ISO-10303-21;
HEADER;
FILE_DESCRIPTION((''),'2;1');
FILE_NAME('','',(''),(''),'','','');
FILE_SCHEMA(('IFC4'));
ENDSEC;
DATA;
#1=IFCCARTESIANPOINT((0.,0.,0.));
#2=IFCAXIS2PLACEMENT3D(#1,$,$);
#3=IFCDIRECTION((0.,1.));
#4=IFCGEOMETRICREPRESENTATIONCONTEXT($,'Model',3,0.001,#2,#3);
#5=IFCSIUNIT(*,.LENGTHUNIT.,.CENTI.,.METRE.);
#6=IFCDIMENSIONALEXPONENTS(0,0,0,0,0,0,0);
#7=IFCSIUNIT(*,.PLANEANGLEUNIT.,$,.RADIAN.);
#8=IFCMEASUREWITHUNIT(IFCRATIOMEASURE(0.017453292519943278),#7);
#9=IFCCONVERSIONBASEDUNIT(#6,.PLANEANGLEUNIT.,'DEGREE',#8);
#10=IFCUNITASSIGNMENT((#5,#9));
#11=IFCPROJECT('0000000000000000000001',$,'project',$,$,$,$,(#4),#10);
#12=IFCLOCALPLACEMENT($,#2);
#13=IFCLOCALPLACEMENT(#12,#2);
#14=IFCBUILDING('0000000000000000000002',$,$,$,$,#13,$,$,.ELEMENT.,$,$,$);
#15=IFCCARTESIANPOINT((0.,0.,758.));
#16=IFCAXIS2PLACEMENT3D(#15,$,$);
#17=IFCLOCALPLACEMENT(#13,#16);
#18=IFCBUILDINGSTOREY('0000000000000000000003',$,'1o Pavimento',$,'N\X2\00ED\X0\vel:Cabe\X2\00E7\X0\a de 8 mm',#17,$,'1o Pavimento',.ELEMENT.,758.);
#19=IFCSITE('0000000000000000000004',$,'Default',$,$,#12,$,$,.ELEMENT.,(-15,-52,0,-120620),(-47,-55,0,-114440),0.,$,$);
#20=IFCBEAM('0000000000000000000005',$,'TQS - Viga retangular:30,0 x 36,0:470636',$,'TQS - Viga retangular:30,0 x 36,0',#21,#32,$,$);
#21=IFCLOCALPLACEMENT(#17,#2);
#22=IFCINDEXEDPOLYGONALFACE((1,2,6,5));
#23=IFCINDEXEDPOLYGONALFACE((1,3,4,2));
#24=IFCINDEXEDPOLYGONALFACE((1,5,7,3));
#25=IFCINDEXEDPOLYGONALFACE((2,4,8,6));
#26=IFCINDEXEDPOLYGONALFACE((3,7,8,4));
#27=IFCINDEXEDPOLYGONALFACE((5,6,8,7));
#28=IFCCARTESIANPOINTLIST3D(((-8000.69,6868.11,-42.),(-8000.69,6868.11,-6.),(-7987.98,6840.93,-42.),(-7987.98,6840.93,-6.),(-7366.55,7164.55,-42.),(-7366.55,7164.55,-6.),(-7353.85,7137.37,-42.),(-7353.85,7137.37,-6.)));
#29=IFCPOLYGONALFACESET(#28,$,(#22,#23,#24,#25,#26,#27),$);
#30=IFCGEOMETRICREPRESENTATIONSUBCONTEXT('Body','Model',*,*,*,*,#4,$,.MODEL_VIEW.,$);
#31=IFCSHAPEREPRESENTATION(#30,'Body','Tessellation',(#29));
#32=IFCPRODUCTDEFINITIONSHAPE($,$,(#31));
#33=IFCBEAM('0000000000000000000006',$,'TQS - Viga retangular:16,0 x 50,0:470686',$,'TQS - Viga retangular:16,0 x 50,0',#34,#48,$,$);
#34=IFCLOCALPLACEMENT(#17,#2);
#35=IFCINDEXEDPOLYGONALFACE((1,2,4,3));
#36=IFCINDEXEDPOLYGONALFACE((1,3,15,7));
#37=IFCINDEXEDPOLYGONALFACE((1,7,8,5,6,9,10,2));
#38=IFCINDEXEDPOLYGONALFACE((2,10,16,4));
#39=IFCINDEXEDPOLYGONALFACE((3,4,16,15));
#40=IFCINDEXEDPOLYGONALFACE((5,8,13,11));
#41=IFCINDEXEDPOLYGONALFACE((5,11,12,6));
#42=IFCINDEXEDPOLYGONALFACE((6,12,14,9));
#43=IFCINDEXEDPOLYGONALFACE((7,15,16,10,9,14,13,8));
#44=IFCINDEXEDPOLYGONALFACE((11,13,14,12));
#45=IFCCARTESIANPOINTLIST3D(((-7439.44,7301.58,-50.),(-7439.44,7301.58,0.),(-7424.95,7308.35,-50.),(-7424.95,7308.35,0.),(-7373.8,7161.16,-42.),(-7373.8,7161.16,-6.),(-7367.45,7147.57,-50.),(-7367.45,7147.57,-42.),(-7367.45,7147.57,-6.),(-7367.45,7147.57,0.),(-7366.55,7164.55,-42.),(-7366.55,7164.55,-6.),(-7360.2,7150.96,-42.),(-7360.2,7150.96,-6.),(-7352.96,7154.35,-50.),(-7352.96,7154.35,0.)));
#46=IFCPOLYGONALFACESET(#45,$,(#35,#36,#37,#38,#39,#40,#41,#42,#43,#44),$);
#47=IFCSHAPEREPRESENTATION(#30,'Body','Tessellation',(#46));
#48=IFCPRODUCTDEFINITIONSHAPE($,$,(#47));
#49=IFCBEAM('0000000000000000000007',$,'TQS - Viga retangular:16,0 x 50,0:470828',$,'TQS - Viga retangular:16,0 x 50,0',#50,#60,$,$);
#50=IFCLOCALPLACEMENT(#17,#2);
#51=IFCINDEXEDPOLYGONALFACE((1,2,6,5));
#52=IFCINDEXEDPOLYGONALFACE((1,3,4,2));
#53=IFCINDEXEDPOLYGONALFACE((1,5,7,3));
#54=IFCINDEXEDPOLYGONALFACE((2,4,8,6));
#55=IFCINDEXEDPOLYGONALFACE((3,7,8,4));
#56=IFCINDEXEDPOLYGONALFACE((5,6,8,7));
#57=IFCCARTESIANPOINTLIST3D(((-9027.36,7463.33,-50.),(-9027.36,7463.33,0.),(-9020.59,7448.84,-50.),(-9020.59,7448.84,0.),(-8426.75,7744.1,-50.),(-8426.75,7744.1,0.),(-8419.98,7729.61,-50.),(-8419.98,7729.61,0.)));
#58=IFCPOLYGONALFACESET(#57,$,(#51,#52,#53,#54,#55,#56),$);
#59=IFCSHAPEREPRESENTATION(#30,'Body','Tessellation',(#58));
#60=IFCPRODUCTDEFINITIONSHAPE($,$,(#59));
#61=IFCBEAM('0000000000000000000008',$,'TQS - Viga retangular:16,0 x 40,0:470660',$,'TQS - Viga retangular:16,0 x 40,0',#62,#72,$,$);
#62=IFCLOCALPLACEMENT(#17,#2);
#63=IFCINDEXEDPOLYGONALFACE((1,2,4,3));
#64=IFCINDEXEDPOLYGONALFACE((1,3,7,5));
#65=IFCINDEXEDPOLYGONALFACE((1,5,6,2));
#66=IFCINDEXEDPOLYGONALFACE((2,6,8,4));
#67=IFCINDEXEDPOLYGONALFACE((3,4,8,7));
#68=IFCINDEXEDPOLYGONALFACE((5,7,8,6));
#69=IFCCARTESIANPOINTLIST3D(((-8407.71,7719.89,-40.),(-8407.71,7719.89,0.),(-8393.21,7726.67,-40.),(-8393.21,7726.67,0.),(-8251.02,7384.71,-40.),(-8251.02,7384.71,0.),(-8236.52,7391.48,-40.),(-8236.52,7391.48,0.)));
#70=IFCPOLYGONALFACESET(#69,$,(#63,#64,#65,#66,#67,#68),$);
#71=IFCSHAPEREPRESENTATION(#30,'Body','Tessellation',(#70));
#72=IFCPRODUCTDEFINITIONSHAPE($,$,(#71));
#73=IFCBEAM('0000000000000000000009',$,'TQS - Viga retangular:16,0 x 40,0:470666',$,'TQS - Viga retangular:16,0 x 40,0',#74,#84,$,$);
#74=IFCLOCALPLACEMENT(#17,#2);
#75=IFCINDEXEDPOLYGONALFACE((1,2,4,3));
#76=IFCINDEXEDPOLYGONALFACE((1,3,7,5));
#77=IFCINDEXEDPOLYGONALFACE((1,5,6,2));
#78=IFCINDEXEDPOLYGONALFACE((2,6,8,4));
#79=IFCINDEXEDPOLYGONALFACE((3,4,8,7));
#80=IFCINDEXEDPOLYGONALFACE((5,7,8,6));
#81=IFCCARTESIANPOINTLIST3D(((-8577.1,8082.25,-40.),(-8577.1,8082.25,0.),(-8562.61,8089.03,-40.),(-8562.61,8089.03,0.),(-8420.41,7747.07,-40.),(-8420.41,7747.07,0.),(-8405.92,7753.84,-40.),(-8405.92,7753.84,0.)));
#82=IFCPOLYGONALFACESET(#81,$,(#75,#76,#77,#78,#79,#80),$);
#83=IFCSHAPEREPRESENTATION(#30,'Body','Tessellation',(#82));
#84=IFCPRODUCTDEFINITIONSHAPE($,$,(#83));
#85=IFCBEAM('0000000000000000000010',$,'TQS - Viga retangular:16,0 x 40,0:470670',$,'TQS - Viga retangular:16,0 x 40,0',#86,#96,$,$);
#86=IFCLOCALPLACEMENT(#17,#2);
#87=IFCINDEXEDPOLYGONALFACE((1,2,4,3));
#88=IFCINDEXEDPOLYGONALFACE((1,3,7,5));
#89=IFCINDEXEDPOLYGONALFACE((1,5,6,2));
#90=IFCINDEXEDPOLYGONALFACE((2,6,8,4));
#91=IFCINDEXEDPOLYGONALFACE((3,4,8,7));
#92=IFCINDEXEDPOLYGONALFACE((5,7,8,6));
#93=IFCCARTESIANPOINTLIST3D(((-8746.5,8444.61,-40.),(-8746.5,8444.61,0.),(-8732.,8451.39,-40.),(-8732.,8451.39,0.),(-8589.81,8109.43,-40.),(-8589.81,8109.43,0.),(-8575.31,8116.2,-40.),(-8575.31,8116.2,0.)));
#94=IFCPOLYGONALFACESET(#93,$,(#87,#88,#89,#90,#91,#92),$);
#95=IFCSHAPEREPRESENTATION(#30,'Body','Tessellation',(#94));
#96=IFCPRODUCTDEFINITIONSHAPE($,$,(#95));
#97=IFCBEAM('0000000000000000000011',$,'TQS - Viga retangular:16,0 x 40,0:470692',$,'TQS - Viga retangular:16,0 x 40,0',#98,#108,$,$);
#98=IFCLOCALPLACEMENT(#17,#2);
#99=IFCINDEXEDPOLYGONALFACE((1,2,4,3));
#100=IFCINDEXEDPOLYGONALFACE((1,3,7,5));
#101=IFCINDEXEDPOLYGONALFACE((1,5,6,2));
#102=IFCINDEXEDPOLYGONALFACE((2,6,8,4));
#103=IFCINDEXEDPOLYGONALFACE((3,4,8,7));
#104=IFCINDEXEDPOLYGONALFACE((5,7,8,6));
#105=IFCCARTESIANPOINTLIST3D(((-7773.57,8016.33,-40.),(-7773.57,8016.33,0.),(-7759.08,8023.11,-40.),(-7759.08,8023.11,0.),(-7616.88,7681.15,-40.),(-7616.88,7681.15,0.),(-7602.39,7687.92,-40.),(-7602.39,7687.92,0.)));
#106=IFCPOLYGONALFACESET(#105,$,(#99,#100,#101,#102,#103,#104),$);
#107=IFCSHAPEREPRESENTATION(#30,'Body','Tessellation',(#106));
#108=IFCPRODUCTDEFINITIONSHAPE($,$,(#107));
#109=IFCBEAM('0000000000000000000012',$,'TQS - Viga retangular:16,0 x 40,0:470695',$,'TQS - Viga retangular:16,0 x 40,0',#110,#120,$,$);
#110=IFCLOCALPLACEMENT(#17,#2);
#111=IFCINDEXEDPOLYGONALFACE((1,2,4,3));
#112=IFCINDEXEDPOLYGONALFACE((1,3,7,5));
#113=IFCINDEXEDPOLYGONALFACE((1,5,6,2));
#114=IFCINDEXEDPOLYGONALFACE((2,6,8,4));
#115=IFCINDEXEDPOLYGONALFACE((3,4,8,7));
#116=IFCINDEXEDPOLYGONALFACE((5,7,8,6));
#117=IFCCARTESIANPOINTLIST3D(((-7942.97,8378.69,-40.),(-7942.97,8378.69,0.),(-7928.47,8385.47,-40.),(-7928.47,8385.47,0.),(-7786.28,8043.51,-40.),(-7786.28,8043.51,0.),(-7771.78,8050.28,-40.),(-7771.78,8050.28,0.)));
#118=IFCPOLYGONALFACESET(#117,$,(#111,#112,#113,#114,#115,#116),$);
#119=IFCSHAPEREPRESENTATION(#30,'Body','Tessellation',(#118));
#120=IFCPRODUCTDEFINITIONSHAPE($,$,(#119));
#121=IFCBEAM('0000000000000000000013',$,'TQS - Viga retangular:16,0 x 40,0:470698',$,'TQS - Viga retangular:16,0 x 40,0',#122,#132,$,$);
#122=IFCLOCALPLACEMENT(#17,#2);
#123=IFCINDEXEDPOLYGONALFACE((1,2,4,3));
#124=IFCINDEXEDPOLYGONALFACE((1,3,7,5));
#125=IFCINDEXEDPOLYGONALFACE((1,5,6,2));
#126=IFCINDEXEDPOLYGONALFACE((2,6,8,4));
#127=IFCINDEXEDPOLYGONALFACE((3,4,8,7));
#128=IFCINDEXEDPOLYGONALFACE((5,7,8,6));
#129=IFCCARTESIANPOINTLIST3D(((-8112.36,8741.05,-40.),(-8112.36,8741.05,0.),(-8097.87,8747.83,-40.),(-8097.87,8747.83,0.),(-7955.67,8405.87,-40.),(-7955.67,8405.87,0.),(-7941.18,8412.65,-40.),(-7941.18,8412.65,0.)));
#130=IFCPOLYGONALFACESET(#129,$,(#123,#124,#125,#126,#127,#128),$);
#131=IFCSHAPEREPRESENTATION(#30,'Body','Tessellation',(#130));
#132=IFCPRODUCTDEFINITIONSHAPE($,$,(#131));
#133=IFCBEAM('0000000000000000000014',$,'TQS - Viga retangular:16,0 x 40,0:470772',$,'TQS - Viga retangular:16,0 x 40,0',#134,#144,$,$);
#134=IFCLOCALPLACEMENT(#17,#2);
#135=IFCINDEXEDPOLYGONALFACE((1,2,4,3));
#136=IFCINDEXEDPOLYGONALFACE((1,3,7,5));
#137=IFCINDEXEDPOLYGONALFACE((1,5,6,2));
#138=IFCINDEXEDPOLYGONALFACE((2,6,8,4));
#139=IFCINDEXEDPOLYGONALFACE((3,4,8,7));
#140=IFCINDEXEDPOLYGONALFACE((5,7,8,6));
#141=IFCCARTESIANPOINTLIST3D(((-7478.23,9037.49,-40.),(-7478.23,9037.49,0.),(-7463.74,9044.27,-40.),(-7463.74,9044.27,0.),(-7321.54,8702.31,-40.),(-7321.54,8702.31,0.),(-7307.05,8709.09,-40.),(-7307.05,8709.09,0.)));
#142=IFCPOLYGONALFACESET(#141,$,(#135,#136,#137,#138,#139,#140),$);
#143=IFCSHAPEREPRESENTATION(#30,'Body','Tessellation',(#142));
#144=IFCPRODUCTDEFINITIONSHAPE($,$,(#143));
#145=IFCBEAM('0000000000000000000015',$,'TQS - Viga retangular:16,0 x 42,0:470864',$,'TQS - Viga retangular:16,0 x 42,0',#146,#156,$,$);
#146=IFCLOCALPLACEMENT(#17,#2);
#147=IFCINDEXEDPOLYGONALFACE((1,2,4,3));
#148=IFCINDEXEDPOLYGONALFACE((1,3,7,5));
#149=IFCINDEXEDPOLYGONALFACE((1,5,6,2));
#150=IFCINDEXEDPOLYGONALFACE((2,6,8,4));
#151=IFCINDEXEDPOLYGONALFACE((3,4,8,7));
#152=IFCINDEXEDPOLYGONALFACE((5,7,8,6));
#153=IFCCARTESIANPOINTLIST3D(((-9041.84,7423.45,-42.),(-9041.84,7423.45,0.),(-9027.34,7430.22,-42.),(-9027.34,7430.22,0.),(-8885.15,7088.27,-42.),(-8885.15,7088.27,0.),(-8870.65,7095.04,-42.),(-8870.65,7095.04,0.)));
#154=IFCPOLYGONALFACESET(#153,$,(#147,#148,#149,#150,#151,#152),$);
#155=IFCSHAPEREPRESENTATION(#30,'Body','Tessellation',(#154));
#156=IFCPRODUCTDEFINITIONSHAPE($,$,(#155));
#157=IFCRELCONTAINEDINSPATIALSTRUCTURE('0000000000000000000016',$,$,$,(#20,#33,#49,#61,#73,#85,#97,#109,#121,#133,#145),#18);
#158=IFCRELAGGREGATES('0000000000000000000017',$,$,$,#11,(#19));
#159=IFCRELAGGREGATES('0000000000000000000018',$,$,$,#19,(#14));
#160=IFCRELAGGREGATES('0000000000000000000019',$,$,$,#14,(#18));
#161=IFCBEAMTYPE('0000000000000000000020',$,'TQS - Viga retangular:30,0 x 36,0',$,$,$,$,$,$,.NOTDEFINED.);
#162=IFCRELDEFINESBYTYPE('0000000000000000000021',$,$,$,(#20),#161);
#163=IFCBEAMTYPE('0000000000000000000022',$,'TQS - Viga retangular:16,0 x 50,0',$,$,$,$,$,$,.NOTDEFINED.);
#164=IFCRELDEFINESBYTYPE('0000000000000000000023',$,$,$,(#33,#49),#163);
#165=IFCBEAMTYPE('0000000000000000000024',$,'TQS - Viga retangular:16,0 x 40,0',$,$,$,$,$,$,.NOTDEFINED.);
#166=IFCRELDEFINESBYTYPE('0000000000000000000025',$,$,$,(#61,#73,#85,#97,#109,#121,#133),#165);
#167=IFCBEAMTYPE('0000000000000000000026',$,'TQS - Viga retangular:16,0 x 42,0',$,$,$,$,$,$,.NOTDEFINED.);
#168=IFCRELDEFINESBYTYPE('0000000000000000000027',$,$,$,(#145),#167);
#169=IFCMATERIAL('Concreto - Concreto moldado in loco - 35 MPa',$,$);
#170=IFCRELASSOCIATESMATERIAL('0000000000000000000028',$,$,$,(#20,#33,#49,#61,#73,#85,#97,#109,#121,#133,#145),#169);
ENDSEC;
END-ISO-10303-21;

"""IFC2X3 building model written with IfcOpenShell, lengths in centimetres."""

from ifc_helpers import new_model, entity, si_unit, converted_unit, direction, frame, frame_2d, origin, origin_2d_with_axis, place, context, subcontext, project, spatial, polyline, rectangle, extrude, boolean, clip, bounded_halfspace, material, type_object, element, save


model = new_model("IFC2X3")

# Units and contexts
model_context = context("Model", 3, precision=0.001, world=origin(), true_north=direction((0.0, 1.0)))
body_context = subcontext(model_context, "Body", "Model", "MODEL_VIEW")
ifc_project = project(units=[si_unit("LENGTHUNIT", "METRE", prefix="CENTI"), converted_unit("PLANEANGLEUNIT", "DEGREE", entity("IfcRatioMeasure", 0.017453292519943278), si_unit("PLANEANGLEUNIT", "RADIAN"), dimensions=[0, 0, 0, 0, 0, 0, 0])], contexts=[model_context])

# Site, building, storey
site_placement = place(None, origin())
site = spatial("IfcSite", under=ifc_project, at=site_placement, Name="Default", CompositionType="ELEMENT", RefLatitude=(-15, -52, 0, -120620), RefLongitude=(-47, -55, 0, -114440), RefElevation=0.0)
building_placement = place(site_placement, origin())
building = spatial("IfcBuilding", under=site, at=building_placement, CompositionType="ELEMENT")
storey_placement = place(building_placement, frame((0.0, 0.0, 758.0)))
storey = spatial("IfcBuildingStorey", under=building, at=storey_placement, Name="1o Pavimento", ObjectType="Nível:Cabeça de 8 mm", LongName="1o Pavimento", CompositionType="ELEMENT", Elevation=758.0)

# Beams
ifc_material_1 = material(Name="Concreto - Concreto moldado in loco - 35 MPa")
beam_type_1 = type_object("IfcBeamType", Name="TQS - Viga retangular:30,0 x 36,0", PredefinedType="NOTDEFINED")
beam_1_placement = place(storey_placement, frame((-7994.33, 6854.52, -6.0), z_axis=(0.0, 0.0, 1.0), x_axis=(0.905902, 0.423488, 0.0)))
element("IfcBeam", 1, at=beam_1_placement, inside=storey, type_object=beam_type_1, material=ifc_material_1, Name="TQS - Viga retangular:30,0 x 36,0:470636", ObjectType="TQS - Viga retangular:30,0 x 36,0", context=body_context, shape_type="SweptSolid", body=[
    extrude(rectangle(XDim=36.0, YDim=30.0, at=origin_2d_with_axis()), frame((0.0, 0.0, -18.0), z_axis=(1.0, 0.0, 0.0), x_axis=(0.0, 0.0, -1.0)), (0.0, 0.0, 1.0), 700.0),
])
beam_type_2 = type_object("IfcBeamType", Name="TQS - Viga retangular:16,0 x 50,0", PredefinedType="NOTDEFINED")
beam_2_placement = place(storey_placement, frame((-7360.2, 7150.96, 0.0), z_axis=(0.0, 0.0, 1.0), x_axis=(-0.423488, 0.905902, 0.0)))
element("IfcBeam", 2, at=beam_2_placement, inside=storey, type_object=beam_type_2, material=ifc_material_1, Name="TQS - Viga retangular:16,0 x 50,0:470686", ObjectType="TQS - Viga retangular:16,0 x 50,0", context=body_context, shape_type="SweptSolid", body=[
    boolean("DIFFERENCE", clip(extrude(rectangle(XDim=50.0, YDim=16.0, at=frame_2d((0.0, 0.0), x_axis=(1.0, 0.0))), frame((0.0, 0.0, -25.0), z_axis=(1.0, 0.0, 0.0), x_axis=(0.0, 0.0, -1.0)), (0.0, 0.0, 1.0), 170.0), bounded_halfspace(frame((15.0, 0.0, -42.0), z_axis=(-1.0, 0.0, 0.0), x_axis=(0.0, 1.0, 0.0)), False, frame((0.0, 0.0, -25.0), z_axis=(1.0, 0.0, 0.0), x_axis=(0.0, 0.0, -1.0)), polyline([(17.0, 0.0), (-19.0, 0.0), (-19.0, 8.0), (-9.0, 8.0), (17.0, 8.0), (17.0, 0.0)]))), extrude(rectangle(XDim=36.0, YDim=8.0, at=frame_2d((0.0, 0.0), x_axis=(0.0, 1.0))), frame((0.0, 4.0, -24.0), z_axis=(-1.0, 0.0, 0.0), x_axis=(0.0, -1.0, 0.0)), (0.0, 0.0, -1.0), 15.0)),
])
beam_3_placement = place(storey_placement, frame((-9023.98, 7456.08, 0.0), z_axis=(0.0, 0.0, 1.0), x_axis=(0.905902, 0.423488, 0.0)))
element("IfcBeam", 3, at=beam_3_placement, inside=storey, type_object=beam_type_2, material=ifc_material_1, Name="TQS - Viga retangular:16,0 x 50,0:470828", ObjectType="TQS - Viga retangular:16,0 x 50,0", context=body_context, shape_type="SweptSolid", body=[
    extrude(rectangle(XDim=50.0, YDim=16.0, at=frame_2d((0.0, 0.0), x_axis=(1.0, 0.0))), frame((0.0, 0.0, -25.0), z_axis=(1.0, 0.0, 0.0), x_axis=(0.0, 0.0, -1.0)), (0.0, 0.0, 1.0), 663.0),
])
beam_type_3 = type_object("IfcBeamType", Name="TQS - Viga retangular:16,0 x 40,0", PredefinedType="NOTDEFINED")
beam_4_placement = place(storey_placement, frame((-8240.38, 7380.85, 0.0), z_axis=(0.0, 0.0, 1.0), x_axis=(-0.423488, 0.905902, 0.0)))
element("IfcBeam", 4, at=beam_4_placement, inside=storey, type_object=beam_type_3, material=ifc_material_1, Name="TQS - Viga retangular:16,0 x 40,0:470660", ObjectType="TQS - Viga retangular:16,0 x 40,0", context=body_context, shape_type="SweptSolid", body=[
    extrude(rectangle(XDim=40.0, YDim=16.0, at=frame_2d((0.0, 0.0), x_axis=(1.0, 0.0))), frame((8.0, 0.0, -20.0), z_axis=(1.0, 0.0, 0.0), x_axis=(0.0, 0.0, -1.0)), (0.0, 0.0, 1.0), 370.0),
])
beam_5_placement = place(storey_placement, frame((-8409.78, 7743.21, 0.0), z_axis=(0.0, 0.0, 1.0), x_axis=(-0.423488, 0.905902, 0.0)))
element("IfcBeam", 5, at=beam_5_placement, inside=storey, type_object=beam_type_3, material=ifc_material_1, Name="TQS - Viga retangular:16,0 x 40,0:470666", ObjectType="TQS - Viga retangular:16,0 x 40,0", context=body_context, shape_type="SweptSolid", body=[
    extrude(rectangle(XDim=40.0, YDim=16.0, at=origin_2d_with_axis()), frame((8.0, 0.0, -20.0), z_axis=(1.0, 0.0, 0.0), x_axis=(0.0, 0.0, -1.0)), (0.0, 0.0, 1.0), 370.0),
])
beam_6_placement = place(storey_placement, frame((-8579.17, 8105.57, 0.0), z_axis=(0.0, 0.0, 1.0), x_axis=(-0.423488, 0.905902, 0.0)))
element("IfcBeam", 6, at=beam_6_placement, inside=storey, type_object=beam_type_3, material=ifc_material_1, Name="TQS - Viga retangular:16,0 x 40,0:470670", ObjectType="TQS - Viga retangular:16,0 x 40,0", context=body_context, shape_type="SweptSolid", body=[
    extrude(rectangle(XDim=40.0, YDim=16.0, at=frame_2d((0.0, 0.0), x_axis=(1.0, 0.0))), frame((8.0, 0.0, -20.0), z_axis=(1.0, 0.0, 0.0), x_axis=(0.0, 0.0, -1.0)), (0.0, 0.0, 1.0), 370.0),
])
beam_7_placement = place(storey_placement, frame((-7606.25, 7677.29, 0.0), z_axis=(0.0, 0.0, 1.0), x_axis=(-0.423488, 0.905902, 0.0)))
element("IfcBeam", 7, at=beam_7_placement, inside=storey, type_object=beam_type_3, material=ifc_material_1, Name="TQS - Viga retangular:16,0 x 40,0:470692", ObjectType="TQS - Viga retangular:16,0 x 40,0", context=body_context, shape_type="SweptSolid", body=[
    extrude(rectangle(XDim=40.0, YDim=16.0, at=frame_2d((0.0, 0.0), x_axis=(1.0, 0.0))), frame((8.0, 0.0, -20.0), z_axis=(1.0, 0.0, 0.0), x_axis=(0.0, 0.0, -1.0)), (0.0, 0.0, 1.0), 370.0),
])
beam_8_placement = place(storey_placement, frame((-7775.64, 8039.65, 0.0), z_axis=(0.0, 0.0, 1.0), x_axis=(-0.423488, 0.905902, 0.0)))
element("IfcBeam", 8, at=beam_8_placement, inside=storey, type_object=beam_type_3, material=ifc_material_1, Name="TQS - Viga retangular:16,0 x 40,0:470695", ObjectType="TQS - Viga retangular:16,0 x 40,0", context=body_context, shape_type="SweptSolid", body=[
    extrude(rectangle(XDim=40.0, YDim=16.0, at=origin_2d_with_axis()), frame((8.0, 0.0, -20.0), z_axis=(1.0, 0.0, 0.0), x_axis=(0.0, 0.0, -1.0)), (0.0, 0.0, 1.0), 370.0),
])
beam_9_placement = place(storey_placement, frame((-7945.04, 8402.01, 0.0), z_axis=(0.0, 0.0, 1.0), x_axis=(-0.423488, 0.905902, 0.0)))
element("IfcBeam", 9, at=beam_9_placement, inside=storey, type_object=beam_type_3, material=ifc_material_1, Name="TQS - Viga retangular:16,0 x 40,0:470698", ObjectType="TQS - Viga retangular:16,0 x 40,0", context=body_context, shape_type="SweptSolid", body=[
    extrude(rectangle(XDim=40.0, YDim=16.0, at=frame_2d((0.0, 0.0), x_axis=(1.0, 0.0))), frame((8.0, 0.0, -20.0), z_axis=(1.0, 0.0, 0.0), x_axis=(0.0, 0.0, -1.0)), (0.0, 0.0, 1.0), 370.0),
])
beam_10_placement = place(storey_placement, frame((-7310.91, 8698.45, 0.0), z_axis=(0.0, 0.0, 1.0), x_axis=(-0.423488, 0.905902, 0.0)))
element("IfcBeam", 10, at=beam_10_placement, inside=storey, type_object=beam_type_3, material=ifc_material_1, Name="TQS - Viga retangular:16,0 x 40,0:470772", ObjectType="TQS - Viga retangular:16,0 x 40,0", context=body_context, shape_type="SweptSolid", body=[
    extrude(rectangle(XDim=40.0, YDim=16.0, at=origin_2d_with_axis()), frame((8.0, 0.0, -20.0), z_axis=(1.0, 0.0, 0.0), x_axis=(0.0, 0.0, -1.0)), (0.0, 0.0, 1.0), 370.0),
])
beam_type_4 = type_object("IfcBeamType", Name="TQS - Viga retangular:16,0 x 42,0", PredefinedType="NOTDEFINED")
beam_11_placement = place(storey_placement, frame((-8874.51, 7084.41, 0.0), z_axis=(0.0, 0.0, 1.0), x_axis=(-0.423488, 0.905902, 0.0)))
element("IfcBeam", 11, at=beam_11_placement, inside=storey, type_object=beam_type_4, material=ifc_material_1, Name="TQS - Viga retangular:16,0 x 42,0:470864", ObjectType="TQS - Viga retangular:16,0 x 42,0", context=body_context, shape_type="SweptSolid", body=[
    extrude(rectangle(XDim=42.0, YDim=16.0, at=origin_2d_with_axis()), frame((8.0, 0.0, -21.0), z_axis=(1.0, 0.0, 0.0), x_axis=(0.0, 0.0, -1.0)), (0.0, 0.0, 1.0), 370.0),
])

save(model, "model.ifc")
